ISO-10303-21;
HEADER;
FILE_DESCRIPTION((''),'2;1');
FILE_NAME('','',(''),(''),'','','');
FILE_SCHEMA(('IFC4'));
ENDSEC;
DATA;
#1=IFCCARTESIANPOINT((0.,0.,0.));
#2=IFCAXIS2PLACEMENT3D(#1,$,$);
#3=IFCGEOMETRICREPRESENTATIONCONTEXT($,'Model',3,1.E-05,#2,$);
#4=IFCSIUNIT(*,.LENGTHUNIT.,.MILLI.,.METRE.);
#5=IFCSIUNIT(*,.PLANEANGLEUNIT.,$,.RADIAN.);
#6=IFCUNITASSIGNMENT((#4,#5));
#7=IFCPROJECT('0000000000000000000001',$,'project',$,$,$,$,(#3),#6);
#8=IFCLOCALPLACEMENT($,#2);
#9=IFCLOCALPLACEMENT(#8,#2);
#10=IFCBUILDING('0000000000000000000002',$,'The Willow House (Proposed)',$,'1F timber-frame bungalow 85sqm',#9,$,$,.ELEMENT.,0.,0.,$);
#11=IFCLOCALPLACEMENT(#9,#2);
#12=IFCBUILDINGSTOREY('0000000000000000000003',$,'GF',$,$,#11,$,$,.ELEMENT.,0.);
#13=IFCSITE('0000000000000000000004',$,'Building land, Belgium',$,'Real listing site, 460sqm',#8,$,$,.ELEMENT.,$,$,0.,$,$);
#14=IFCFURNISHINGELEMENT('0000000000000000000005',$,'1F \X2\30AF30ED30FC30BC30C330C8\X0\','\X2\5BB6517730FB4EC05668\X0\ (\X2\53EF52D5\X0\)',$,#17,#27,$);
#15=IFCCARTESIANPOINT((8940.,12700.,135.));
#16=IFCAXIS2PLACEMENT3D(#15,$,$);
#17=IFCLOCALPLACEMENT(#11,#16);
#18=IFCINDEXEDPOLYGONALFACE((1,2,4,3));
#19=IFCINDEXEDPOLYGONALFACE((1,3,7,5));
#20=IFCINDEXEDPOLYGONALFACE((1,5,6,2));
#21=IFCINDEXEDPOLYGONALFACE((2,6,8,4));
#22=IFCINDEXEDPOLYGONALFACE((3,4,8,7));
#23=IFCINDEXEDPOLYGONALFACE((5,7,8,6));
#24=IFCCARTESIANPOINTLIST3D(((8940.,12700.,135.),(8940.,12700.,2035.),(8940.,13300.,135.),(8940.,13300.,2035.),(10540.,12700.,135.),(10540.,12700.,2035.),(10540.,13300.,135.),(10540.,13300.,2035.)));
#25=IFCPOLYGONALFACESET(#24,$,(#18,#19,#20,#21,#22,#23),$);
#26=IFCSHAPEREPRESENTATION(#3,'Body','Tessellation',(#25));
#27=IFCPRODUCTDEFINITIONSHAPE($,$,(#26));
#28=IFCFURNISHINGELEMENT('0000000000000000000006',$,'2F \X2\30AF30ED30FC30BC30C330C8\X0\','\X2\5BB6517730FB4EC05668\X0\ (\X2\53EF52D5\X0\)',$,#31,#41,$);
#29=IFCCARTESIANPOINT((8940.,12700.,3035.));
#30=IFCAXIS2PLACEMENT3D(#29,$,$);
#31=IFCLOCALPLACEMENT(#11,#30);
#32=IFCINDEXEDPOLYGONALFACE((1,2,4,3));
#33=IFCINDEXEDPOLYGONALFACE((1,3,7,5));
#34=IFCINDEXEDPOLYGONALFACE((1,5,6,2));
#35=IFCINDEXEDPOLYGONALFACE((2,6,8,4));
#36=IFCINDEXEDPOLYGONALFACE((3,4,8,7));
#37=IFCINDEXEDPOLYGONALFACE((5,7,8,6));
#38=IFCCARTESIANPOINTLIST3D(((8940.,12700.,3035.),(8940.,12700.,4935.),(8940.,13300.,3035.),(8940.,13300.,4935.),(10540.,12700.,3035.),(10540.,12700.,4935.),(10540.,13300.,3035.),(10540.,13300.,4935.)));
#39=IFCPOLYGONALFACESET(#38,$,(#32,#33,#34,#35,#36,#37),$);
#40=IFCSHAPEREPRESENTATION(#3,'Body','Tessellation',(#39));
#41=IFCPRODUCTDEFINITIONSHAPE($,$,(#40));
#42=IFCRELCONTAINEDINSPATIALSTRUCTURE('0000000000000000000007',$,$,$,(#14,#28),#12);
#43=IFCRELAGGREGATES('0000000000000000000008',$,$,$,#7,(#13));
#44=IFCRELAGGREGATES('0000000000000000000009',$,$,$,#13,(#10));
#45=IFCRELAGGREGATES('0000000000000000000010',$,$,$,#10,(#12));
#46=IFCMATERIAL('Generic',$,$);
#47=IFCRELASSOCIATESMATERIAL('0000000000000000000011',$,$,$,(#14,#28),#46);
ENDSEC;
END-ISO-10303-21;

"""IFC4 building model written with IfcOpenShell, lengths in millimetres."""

from ifc_helpers import new_model, si_unit, frame, frame_2d, origin, place, context, project, spatial, rectangle, extrude, material, element, save


model = new_model("IFC4")

# Units and contexts
model_context = context("Model", 3, precision=1e-05, world=origin())
ifc_project = project(units=[si_unit("LENGTHUNIT", "METRE", prefix="MILLI"), si_unit("PLANEANGLEUNIT", "RADIAN")], contexts=[model_context])

# Site, building, storey
site_placement = place(None, origin())
site = spatial("IfcSite", under=ifc_project, at=site_placement, Name="Building land, Belgium", ObjectType="Real listing site, 460sqm", CompositionType="ELEMENT", RefElevation=0.0)
building_placement = place(site_placement, origin())
building = spatial("IfcBuilding", under=site, at=building_placement, Name="The Willow House (Proposed)", ObjectType="1F timber-frame bungalow 85sqm", CompositionType="ELEMENT", ElevationOfRefHeight=0.0, ElevationOfTerrain=0.0)
storey_placement = place(building_placement, origin())
storey = spatial("IfcBuildingStorey", under=building, at=storey_placement, Name="GF", CompositionType="ELEMENT", Elevation=0.0)

# Shared definitions
ifc_material_1 = material(Name="Generic")

# Furnishing elements
furnishing_1_placement = place(storey_placement, frame((8940.0, 12700.0, 135.0)))
element("IfcFurnishingElement", 1, at=furnishing_1_placement, inside=storey, material=ifc_material_1, Name="1F クローゼット", Description="家具・什器 (可動)", context=model_context, shape_type="SweptSolid", body=[
    extrude(rectangle(XDim=1600.0, YDim=600.0, at=frame_2d((800.0, 300.0))), frame((8940.0, 12700.0, 135.0)), (0.0, 0.0, 1.0), 1900.0),
])
furnishing_2_placement = place(storey_placement, frame((8940.0, 12700.0, 3035.0)))
element("IfcFurnishingElement", 2, at=furnishing_2_placement, inside=storey, material=ifc_material_1, Name="2F クローゼット", Description="家具・什器 (可動)", context=model_context, shape_type="SweptSolid", body=[
    extrude(rectangle(XDim=1600.0, YDim=600.0, at=frame_2d((800.0, 300.0))), frame((8940.0, 12700.0, 3035.0)), (0.0, 0.0, 1.0), 1900.0),
])

save(model, "model.ifc")
